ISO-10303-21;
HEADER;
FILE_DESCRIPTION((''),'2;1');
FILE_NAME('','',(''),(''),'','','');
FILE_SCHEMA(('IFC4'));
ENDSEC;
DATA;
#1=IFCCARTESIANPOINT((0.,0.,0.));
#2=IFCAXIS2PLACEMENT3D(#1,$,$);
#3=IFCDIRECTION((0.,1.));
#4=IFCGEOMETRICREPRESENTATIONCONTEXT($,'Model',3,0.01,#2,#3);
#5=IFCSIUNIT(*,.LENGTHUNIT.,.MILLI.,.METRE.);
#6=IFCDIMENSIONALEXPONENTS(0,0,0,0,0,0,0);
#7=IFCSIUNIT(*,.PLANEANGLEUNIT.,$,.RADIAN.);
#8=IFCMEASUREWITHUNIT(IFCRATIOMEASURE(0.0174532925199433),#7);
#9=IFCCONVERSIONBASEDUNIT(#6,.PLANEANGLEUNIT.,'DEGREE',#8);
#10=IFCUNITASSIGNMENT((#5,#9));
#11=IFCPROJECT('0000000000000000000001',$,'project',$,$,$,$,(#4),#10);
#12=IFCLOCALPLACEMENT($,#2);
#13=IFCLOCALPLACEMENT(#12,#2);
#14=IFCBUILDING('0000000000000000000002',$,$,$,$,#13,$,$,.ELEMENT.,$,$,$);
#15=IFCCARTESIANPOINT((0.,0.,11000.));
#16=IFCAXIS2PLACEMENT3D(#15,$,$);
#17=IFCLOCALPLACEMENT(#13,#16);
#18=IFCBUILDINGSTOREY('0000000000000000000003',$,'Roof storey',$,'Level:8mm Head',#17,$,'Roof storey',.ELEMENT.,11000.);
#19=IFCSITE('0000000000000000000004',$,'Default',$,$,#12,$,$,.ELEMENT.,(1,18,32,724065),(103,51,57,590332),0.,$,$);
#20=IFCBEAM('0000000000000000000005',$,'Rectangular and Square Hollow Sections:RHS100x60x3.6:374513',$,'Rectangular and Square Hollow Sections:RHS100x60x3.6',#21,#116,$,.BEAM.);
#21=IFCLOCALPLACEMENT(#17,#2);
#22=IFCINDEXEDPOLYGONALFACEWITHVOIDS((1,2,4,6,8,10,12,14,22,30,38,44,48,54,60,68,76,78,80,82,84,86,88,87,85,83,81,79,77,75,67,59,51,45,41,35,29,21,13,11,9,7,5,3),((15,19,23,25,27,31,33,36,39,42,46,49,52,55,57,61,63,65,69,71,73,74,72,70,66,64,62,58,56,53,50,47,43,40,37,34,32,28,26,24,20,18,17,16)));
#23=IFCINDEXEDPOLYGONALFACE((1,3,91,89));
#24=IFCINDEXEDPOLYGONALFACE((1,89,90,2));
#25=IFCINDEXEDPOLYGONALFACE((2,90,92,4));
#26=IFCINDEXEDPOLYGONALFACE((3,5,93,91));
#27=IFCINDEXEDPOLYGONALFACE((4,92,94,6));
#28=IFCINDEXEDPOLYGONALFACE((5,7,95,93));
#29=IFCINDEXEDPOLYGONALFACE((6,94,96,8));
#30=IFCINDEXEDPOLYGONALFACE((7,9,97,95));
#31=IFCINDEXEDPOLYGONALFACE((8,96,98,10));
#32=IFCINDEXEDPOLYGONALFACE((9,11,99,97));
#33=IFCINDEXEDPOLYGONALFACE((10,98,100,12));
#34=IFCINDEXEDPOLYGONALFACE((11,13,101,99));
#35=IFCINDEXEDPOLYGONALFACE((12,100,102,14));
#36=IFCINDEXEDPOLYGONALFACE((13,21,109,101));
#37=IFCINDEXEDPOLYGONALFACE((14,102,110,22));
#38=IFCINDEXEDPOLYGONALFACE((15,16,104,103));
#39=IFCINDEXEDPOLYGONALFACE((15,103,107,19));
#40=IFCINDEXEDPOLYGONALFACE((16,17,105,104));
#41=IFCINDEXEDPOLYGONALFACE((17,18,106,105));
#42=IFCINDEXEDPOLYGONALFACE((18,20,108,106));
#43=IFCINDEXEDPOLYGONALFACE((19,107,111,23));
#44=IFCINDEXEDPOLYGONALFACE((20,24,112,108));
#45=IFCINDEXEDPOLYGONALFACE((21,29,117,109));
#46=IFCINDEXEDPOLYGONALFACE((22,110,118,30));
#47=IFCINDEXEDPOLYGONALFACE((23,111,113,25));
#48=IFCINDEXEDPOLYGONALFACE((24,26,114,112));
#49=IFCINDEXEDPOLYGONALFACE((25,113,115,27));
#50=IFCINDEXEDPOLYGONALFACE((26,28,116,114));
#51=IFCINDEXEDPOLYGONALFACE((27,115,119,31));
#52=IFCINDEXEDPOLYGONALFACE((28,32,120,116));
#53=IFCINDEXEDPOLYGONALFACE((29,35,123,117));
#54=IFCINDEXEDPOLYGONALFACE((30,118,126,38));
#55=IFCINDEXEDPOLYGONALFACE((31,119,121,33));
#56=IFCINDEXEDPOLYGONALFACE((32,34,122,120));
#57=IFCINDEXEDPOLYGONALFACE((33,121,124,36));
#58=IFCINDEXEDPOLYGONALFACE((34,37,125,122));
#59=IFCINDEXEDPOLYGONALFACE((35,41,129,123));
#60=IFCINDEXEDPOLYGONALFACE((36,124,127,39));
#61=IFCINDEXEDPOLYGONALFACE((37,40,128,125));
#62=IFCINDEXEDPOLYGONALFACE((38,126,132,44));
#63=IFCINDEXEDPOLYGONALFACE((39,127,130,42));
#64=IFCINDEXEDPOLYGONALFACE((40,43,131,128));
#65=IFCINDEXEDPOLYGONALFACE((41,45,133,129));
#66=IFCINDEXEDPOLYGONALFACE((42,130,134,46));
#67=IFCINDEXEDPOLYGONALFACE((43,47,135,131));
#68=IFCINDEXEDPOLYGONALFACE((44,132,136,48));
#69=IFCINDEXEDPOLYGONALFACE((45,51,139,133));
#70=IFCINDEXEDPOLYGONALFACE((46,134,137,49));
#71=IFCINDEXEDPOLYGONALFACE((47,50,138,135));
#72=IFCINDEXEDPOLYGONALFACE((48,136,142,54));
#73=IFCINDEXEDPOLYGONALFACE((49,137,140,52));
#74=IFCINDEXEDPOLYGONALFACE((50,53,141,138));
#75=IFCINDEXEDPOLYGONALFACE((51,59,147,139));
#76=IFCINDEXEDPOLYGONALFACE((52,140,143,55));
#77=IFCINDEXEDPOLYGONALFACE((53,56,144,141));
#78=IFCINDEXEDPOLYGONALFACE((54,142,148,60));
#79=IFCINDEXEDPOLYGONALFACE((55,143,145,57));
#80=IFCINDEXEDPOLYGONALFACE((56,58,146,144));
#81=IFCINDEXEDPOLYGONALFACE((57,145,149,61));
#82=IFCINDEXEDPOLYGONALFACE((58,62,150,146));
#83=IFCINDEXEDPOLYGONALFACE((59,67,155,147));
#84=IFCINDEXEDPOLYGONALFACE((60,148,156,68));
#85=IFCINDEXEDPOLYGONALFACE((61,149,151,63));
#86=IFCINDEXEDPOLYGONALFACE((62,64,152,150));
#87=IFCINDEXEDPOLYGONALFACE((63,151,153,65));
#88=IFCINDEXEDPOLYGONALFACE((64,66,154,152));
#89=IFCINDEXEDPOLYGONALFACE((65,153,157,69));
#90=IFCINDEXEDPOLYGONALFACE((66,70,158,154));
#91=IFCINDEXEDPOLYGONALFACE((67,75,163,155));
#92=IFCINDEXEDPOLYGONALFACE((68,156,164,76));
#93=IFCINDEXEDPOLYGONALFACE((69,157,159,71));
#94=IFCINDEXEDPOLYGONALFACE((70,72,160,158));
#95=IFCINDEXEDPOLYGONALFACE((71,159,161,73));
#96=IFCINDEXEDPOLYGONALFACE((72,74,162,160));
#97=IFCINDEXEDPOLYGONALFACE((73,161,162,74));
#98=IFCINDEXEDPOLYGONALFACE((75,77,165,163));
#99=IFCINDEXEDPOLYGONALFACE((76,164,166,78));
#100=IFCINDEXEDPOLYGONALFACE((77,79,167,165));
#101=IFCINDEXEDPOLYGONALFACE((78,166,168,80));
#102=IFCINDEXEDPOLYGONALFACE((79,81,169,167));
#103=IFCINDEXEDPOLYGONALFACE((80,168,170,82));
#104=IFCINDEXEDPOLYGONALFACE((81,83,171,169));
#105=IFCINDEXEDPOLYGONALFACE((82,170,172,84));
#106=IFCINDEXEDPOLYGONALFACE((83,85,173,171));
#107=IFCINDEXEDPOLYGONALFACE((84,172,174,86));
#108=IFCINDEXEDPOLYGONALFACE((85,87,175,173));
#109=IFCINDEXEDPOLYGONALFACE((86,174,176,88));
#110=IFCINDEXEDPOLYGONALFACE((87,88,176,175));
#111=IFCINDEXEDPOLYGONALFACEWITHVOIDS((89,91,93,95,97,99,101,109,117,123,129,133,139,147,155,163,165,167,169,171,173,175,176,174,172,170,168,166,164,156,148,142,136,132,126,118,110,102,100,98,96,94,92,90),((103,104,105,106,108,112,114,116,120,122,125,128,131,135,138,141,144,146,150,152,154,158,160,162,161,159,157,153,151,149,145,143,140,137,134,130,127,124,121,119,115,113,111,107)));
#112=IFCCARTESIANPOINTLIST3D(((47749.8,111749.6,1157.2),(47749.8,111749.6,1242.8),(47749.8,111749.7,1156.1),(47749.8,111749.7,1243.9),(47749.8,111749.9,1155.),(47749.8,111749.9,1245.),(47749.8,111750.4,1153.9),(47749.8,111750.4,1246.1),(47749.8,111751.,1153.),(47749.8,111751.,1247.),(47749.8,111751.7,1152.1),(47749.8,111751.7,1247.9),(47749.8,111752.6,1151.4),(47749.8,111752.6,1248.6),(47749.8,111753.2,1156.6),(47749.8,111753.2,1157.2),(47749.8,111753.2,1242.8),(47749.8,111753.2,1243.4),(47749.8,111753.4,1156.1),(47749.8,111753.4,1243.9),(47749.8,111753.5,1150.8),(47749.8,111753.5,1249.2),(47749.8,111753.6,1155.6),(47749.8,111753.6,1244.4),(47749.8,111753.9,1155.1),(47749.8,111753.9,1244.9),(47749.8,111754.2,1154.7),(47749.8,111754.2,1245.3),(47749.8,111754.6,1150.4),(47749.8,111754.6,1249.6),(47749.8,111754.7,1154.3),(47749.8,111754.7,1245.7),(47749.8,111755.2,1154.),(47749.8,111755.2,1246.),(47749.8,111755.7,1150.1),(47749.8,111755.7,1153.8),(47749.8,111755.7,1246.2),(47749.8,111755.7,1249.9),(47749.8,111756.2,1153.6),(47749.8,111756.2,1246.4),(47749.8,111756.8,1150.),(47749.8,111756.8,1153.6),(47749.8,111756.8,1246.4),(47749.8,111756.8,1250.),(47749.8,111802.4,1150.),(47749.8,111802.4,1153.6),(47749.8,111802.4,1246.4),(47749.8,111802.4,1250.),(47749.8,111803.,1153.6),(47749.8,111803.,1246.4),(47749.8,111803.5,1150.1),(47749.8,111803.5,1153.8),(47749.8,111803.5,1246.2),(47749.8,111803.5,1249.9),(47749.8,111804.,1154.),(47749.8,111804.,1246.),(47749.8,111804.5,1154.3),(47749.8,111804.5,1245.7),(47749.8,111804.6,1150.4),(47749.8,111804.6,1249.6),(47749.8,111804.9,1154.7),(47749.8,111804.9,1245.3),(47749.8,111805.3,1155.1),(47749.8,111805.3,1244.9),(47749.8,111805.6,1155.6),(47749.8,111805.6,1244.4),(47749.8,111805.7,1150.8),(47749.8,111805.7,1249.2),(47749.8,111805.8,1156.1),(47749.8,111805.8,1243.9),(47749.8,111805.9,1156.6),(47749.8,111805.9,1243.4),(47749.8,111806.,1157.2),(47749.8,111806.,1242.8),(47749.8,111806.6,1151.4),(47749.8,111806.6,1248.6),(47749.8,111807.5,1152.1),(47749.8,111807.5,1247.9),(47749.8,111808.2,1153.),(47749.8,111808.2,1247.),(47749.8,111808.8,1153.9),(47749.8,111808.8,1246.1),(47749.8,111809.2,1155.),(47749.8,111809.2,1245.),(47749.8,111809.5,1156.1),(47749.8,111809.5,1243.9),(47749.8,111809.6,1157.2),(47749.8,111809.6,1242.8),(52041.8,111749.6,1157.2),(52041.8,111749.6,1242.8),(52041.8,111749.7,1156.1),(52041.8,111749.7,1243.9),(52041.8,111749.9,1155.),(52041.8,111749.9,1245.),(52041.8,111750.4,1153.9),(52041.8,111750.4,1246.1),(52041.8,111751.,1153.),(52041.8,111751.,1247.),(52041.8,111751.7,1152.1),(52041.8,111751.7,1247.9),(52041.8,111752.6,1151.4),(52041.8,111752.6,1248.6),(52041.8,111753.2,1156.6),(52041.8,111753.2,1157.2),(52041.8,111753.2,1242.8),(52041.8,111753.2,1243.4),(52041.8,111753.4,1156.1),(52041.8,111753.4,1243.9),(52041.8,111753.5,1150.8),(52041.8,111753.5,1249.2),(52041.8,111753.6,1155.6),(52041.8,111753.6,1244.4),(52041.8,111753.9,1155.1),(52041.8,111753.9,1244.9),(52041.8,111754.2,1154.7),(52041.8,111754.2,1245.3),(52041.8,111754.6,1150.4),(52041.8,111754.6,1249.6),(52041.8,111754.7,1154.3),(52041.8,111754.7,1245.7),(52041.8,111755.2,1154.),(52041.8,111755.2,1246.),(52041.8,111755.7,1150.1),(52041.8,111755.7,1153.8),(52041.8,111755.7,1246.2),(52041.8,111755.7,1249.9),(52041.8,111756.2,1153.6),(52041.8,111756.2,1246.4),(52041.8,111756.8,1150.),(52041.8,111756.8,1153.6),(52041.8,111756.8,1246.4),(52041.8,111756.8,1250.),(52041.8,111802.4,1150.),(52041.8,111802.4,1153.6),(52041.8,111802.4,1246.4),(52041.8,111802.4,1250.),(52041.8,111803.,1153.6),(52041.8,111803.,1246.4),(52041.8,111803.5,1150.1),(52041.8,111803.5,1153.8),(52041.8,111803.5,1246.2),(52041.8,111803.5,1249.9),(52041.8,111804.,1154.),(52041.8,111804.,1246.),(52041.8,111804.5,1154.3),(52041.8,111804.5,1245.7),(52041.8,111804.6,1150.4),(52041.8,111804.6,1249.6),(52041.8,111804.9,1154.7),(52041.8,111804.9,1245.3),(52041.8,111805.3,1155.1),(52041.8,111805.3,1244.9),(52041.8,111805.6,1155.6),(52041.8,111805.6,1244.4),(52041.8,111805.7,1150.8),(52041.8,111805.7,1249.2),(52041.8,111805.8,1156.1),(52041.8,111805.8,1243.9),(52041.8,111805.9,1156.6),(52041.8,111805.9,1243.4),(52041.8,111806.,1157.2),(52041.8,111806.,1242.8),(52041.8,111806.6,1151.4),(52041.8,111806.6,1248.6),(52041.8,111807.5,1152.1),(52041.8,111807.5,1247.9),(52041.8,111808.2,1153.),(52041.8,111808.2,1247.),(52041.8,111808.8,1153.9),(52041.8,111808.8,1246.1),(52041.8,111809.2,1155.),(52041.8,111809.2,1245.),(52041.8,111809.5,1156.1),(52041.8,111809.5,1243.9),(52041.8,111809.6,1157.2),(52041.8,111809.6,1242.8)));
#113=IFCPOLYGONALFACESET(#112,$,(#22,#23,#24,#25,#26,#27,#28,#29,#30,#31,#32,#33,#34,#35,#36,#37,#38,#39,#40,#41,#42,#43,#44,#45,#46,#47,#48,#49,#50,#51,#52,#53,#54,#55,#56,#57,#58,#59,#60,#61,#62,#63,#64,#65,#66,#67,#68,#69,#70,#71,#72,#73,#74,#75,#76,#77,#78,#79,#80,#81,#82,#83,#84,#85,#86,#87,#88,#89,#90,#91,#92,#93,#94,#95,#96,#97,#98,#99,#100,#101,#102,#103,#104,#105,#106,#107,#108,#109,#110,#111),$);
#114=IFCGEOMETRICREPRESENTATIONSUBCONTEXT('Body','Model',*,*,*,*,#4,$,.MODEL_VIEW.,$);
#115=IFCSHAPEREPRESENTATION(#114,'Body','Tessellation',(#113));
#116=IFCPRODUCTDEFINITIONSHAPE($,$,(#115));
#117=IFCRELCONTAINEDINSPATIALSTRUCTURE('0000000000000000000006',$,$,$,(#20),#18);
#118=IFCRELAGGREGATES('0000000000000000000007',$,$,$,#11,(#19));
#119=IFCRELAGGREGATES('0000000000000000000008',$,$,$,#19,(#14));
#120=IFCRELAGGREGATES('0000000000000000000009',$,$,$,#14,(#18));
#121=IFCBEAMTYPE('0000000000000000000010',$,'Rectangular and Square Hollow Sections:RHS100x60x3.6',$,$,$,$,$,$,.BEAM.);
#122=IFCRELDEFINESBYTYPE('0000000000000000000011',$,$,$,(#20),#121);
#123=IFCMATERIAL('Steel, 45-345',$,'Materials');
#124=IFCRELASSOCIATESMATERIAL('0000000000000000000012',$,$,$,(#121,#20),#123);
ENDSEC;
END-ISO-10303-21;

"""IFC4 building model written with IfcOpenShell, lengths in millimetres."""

from ifc_helpers import new_model, entity, si_unit, converted_unit, direction, frame, origin, place, context, subcontext, project, spatial, indexed_curve, outline, extrude, source, transform, mapped, material, type_object, type_shapes, element, save


model = new_model("IFC4")

# Units and contexts
model_context = context("Model", 3, precision=0.01, world=origin(), true_north=direction((0.0, 1.0)))
body_context = subcontext(model_context, "Body", "Model", "MODEL_VIEW")
ifc_project = project(units=[si_unit("LENGTHUNIT", "METRE", prefix="MILLI"), converted_unit("PLANEANGLEUNIT", "DEGREE", entity("IfcRatioMeasure", 0.0174532925199433), si_unit("PLANEANGLEUNIT", "RADIAN"), dimensions=[0, 0, 0, 0, 0, 0, 0])], contexts=[model_context])

# Site, building, storey
site_placement = place(None, origin())
site = spatial("IfcSite", under=ifc_project, at=site_placement, Name="Default", CompositionType="ELEMENT", RefLatitude=(1, 18, 32, 724065), RefLongitude=(103, 51, 57, 590332), RefElevation=0.0)
building_placement = place(site_placement, origin())
building = spatial("IfcBuilding", under=site, at=building_placement, CompositionType="ELEMENT")
storey_placement = place(building_placement, frame((0.0, 0.0, 11000.0)))
storey = spatial("IfcBuildingStorey", under=building, at=storey_placement, Name="Roof storey", ObjectType="Level:8mm Head", LongName="Roof storey", CompositionType="ELEMENT", Elevation=11000.0)

# Shared definitions
ifc_material = material(Name="Steel, 45-345", Category="Materials")

# Beam
beam_type_1 = type_object("IfcBeamType", Name="Rectangular and Square Hollow Sections:RHS100x60x3.6", PredefinedType="BEAM", material=ifc_material)
shared_shape_1 = source(origin(), body_context, "Body", "SweptSolid", [
    extrude(outline(indexed_curve([(-30.0, -42.8), (-29.9, -43.9), (-29.6, -45.0), (-29.2, -46.1), (-28.6, -47.0), (-27.9, -47.9), (-27.0, -48.6), (-26.1, -49.2), (-25.0, -49.6), (-23.9, -49.9), (-22.8, -50.0), (22.8, -50.0), (23.9, -49.9), (25.0, -49.6), (26.1, -49.2), (27.0, -48.6), (27.9, -47.9), (28.6, -47.0), (29.2, -46.1), (29.6, -45.0), (29.9, -43.9), (30.0, -42.8), (30.0, 42.8), (29.9, 43.9), (29.6, 45.0), (29.2, 46.1), (28.6, 47.0), (27.9, 47.9), (27.0, 48.6), (26.1, 49.2), (25.0, 49.6), (23.9, 49.9), (22.8, 50.0), (-22.8, 50.0), (-23.9, 49.9), (-25.0, 49.6), (-26.1, 49.2), (-27.0, 48.6), (-27.9, 47.9), (-28.6, 47.0), (-29.2, 46.1), (-29.6, 45.0), (-29.9, 43.9), (-30.0, 42.8), (-30.0, -42.8)], self_intersect=False), holes=[indexed_curve([(22.8, -46.4), (-22.8, -46.4), (-23.4, -46.4), (-23.9, -46.2), (-24.4, -46.0), (-24.9, -45.7), (-25.3, -45.3), (-25.7, -44.9), (-26.0, -44.4), (-26.2, -43.9), (-26.4, -43.4), (-26.4, -42.8), (-26.4, 42.8), (-26.4, 43.4), (-26.2, 43.9), (-26.0, 44.4), (-25.7, 44.9), (-25.3, 45.3), (-24.9, 45.7), (-24.4, 46.0), (-23.9, 46.2), (-23.4, 46.4), (-22.8, 46.4), (22.8, 46.4), (23.4, 46.4), (23.9, 46.2), (24.4, 46.0), (24.9, 45.7), (25.3, 45.3), (25.7, 44.9), (26.0, 44.4), (26.2, 43.9), (26.4, 43.4), (26.4, 42.8), (26.4, -42.8), (26.4, -43.4), (26.2, -43.9), (26.0, -44.4), (25.7, -44.9), (25.3, -45.3), (24.9, -45.7), (24.4, -46.0), (23.9, -46.2), (23.4, -46.4), (22.8, -46.4)], self_intersect=False)]), frame((-2139.5, 0.0, 0.0), z_axis=(1.0, 0.0, 0.0), x_axis=(0.0, -1.0, 0.0)), (0.0, 0.0, 1.0), 4292.0),
])
type_shapes(beam_type_1, [shared_shape_1])
for number, where, name in (
    (1, (49889.3, 111779.6, 1200.0), "Rectangular and Square Hollow Sections:RHS100x60x3.6:374513"),
):
    element("IfcBeam", number, at=place(storey_placement, frame(where)), inside=storey, type_object=beam_type_1, material=ifc_material, Name=name, ObjectType="Rectangular and Square Hollow Sections:RHS100x60x3.6", PredefinedType="BEAM", context=body_context, shape_type="MappedRepresentation", body=[
        mapped(shared_shape_1, transform((0.0, 0.0, 0.0), scale=1.0)),
    ])

save(model, "model.ifc")
